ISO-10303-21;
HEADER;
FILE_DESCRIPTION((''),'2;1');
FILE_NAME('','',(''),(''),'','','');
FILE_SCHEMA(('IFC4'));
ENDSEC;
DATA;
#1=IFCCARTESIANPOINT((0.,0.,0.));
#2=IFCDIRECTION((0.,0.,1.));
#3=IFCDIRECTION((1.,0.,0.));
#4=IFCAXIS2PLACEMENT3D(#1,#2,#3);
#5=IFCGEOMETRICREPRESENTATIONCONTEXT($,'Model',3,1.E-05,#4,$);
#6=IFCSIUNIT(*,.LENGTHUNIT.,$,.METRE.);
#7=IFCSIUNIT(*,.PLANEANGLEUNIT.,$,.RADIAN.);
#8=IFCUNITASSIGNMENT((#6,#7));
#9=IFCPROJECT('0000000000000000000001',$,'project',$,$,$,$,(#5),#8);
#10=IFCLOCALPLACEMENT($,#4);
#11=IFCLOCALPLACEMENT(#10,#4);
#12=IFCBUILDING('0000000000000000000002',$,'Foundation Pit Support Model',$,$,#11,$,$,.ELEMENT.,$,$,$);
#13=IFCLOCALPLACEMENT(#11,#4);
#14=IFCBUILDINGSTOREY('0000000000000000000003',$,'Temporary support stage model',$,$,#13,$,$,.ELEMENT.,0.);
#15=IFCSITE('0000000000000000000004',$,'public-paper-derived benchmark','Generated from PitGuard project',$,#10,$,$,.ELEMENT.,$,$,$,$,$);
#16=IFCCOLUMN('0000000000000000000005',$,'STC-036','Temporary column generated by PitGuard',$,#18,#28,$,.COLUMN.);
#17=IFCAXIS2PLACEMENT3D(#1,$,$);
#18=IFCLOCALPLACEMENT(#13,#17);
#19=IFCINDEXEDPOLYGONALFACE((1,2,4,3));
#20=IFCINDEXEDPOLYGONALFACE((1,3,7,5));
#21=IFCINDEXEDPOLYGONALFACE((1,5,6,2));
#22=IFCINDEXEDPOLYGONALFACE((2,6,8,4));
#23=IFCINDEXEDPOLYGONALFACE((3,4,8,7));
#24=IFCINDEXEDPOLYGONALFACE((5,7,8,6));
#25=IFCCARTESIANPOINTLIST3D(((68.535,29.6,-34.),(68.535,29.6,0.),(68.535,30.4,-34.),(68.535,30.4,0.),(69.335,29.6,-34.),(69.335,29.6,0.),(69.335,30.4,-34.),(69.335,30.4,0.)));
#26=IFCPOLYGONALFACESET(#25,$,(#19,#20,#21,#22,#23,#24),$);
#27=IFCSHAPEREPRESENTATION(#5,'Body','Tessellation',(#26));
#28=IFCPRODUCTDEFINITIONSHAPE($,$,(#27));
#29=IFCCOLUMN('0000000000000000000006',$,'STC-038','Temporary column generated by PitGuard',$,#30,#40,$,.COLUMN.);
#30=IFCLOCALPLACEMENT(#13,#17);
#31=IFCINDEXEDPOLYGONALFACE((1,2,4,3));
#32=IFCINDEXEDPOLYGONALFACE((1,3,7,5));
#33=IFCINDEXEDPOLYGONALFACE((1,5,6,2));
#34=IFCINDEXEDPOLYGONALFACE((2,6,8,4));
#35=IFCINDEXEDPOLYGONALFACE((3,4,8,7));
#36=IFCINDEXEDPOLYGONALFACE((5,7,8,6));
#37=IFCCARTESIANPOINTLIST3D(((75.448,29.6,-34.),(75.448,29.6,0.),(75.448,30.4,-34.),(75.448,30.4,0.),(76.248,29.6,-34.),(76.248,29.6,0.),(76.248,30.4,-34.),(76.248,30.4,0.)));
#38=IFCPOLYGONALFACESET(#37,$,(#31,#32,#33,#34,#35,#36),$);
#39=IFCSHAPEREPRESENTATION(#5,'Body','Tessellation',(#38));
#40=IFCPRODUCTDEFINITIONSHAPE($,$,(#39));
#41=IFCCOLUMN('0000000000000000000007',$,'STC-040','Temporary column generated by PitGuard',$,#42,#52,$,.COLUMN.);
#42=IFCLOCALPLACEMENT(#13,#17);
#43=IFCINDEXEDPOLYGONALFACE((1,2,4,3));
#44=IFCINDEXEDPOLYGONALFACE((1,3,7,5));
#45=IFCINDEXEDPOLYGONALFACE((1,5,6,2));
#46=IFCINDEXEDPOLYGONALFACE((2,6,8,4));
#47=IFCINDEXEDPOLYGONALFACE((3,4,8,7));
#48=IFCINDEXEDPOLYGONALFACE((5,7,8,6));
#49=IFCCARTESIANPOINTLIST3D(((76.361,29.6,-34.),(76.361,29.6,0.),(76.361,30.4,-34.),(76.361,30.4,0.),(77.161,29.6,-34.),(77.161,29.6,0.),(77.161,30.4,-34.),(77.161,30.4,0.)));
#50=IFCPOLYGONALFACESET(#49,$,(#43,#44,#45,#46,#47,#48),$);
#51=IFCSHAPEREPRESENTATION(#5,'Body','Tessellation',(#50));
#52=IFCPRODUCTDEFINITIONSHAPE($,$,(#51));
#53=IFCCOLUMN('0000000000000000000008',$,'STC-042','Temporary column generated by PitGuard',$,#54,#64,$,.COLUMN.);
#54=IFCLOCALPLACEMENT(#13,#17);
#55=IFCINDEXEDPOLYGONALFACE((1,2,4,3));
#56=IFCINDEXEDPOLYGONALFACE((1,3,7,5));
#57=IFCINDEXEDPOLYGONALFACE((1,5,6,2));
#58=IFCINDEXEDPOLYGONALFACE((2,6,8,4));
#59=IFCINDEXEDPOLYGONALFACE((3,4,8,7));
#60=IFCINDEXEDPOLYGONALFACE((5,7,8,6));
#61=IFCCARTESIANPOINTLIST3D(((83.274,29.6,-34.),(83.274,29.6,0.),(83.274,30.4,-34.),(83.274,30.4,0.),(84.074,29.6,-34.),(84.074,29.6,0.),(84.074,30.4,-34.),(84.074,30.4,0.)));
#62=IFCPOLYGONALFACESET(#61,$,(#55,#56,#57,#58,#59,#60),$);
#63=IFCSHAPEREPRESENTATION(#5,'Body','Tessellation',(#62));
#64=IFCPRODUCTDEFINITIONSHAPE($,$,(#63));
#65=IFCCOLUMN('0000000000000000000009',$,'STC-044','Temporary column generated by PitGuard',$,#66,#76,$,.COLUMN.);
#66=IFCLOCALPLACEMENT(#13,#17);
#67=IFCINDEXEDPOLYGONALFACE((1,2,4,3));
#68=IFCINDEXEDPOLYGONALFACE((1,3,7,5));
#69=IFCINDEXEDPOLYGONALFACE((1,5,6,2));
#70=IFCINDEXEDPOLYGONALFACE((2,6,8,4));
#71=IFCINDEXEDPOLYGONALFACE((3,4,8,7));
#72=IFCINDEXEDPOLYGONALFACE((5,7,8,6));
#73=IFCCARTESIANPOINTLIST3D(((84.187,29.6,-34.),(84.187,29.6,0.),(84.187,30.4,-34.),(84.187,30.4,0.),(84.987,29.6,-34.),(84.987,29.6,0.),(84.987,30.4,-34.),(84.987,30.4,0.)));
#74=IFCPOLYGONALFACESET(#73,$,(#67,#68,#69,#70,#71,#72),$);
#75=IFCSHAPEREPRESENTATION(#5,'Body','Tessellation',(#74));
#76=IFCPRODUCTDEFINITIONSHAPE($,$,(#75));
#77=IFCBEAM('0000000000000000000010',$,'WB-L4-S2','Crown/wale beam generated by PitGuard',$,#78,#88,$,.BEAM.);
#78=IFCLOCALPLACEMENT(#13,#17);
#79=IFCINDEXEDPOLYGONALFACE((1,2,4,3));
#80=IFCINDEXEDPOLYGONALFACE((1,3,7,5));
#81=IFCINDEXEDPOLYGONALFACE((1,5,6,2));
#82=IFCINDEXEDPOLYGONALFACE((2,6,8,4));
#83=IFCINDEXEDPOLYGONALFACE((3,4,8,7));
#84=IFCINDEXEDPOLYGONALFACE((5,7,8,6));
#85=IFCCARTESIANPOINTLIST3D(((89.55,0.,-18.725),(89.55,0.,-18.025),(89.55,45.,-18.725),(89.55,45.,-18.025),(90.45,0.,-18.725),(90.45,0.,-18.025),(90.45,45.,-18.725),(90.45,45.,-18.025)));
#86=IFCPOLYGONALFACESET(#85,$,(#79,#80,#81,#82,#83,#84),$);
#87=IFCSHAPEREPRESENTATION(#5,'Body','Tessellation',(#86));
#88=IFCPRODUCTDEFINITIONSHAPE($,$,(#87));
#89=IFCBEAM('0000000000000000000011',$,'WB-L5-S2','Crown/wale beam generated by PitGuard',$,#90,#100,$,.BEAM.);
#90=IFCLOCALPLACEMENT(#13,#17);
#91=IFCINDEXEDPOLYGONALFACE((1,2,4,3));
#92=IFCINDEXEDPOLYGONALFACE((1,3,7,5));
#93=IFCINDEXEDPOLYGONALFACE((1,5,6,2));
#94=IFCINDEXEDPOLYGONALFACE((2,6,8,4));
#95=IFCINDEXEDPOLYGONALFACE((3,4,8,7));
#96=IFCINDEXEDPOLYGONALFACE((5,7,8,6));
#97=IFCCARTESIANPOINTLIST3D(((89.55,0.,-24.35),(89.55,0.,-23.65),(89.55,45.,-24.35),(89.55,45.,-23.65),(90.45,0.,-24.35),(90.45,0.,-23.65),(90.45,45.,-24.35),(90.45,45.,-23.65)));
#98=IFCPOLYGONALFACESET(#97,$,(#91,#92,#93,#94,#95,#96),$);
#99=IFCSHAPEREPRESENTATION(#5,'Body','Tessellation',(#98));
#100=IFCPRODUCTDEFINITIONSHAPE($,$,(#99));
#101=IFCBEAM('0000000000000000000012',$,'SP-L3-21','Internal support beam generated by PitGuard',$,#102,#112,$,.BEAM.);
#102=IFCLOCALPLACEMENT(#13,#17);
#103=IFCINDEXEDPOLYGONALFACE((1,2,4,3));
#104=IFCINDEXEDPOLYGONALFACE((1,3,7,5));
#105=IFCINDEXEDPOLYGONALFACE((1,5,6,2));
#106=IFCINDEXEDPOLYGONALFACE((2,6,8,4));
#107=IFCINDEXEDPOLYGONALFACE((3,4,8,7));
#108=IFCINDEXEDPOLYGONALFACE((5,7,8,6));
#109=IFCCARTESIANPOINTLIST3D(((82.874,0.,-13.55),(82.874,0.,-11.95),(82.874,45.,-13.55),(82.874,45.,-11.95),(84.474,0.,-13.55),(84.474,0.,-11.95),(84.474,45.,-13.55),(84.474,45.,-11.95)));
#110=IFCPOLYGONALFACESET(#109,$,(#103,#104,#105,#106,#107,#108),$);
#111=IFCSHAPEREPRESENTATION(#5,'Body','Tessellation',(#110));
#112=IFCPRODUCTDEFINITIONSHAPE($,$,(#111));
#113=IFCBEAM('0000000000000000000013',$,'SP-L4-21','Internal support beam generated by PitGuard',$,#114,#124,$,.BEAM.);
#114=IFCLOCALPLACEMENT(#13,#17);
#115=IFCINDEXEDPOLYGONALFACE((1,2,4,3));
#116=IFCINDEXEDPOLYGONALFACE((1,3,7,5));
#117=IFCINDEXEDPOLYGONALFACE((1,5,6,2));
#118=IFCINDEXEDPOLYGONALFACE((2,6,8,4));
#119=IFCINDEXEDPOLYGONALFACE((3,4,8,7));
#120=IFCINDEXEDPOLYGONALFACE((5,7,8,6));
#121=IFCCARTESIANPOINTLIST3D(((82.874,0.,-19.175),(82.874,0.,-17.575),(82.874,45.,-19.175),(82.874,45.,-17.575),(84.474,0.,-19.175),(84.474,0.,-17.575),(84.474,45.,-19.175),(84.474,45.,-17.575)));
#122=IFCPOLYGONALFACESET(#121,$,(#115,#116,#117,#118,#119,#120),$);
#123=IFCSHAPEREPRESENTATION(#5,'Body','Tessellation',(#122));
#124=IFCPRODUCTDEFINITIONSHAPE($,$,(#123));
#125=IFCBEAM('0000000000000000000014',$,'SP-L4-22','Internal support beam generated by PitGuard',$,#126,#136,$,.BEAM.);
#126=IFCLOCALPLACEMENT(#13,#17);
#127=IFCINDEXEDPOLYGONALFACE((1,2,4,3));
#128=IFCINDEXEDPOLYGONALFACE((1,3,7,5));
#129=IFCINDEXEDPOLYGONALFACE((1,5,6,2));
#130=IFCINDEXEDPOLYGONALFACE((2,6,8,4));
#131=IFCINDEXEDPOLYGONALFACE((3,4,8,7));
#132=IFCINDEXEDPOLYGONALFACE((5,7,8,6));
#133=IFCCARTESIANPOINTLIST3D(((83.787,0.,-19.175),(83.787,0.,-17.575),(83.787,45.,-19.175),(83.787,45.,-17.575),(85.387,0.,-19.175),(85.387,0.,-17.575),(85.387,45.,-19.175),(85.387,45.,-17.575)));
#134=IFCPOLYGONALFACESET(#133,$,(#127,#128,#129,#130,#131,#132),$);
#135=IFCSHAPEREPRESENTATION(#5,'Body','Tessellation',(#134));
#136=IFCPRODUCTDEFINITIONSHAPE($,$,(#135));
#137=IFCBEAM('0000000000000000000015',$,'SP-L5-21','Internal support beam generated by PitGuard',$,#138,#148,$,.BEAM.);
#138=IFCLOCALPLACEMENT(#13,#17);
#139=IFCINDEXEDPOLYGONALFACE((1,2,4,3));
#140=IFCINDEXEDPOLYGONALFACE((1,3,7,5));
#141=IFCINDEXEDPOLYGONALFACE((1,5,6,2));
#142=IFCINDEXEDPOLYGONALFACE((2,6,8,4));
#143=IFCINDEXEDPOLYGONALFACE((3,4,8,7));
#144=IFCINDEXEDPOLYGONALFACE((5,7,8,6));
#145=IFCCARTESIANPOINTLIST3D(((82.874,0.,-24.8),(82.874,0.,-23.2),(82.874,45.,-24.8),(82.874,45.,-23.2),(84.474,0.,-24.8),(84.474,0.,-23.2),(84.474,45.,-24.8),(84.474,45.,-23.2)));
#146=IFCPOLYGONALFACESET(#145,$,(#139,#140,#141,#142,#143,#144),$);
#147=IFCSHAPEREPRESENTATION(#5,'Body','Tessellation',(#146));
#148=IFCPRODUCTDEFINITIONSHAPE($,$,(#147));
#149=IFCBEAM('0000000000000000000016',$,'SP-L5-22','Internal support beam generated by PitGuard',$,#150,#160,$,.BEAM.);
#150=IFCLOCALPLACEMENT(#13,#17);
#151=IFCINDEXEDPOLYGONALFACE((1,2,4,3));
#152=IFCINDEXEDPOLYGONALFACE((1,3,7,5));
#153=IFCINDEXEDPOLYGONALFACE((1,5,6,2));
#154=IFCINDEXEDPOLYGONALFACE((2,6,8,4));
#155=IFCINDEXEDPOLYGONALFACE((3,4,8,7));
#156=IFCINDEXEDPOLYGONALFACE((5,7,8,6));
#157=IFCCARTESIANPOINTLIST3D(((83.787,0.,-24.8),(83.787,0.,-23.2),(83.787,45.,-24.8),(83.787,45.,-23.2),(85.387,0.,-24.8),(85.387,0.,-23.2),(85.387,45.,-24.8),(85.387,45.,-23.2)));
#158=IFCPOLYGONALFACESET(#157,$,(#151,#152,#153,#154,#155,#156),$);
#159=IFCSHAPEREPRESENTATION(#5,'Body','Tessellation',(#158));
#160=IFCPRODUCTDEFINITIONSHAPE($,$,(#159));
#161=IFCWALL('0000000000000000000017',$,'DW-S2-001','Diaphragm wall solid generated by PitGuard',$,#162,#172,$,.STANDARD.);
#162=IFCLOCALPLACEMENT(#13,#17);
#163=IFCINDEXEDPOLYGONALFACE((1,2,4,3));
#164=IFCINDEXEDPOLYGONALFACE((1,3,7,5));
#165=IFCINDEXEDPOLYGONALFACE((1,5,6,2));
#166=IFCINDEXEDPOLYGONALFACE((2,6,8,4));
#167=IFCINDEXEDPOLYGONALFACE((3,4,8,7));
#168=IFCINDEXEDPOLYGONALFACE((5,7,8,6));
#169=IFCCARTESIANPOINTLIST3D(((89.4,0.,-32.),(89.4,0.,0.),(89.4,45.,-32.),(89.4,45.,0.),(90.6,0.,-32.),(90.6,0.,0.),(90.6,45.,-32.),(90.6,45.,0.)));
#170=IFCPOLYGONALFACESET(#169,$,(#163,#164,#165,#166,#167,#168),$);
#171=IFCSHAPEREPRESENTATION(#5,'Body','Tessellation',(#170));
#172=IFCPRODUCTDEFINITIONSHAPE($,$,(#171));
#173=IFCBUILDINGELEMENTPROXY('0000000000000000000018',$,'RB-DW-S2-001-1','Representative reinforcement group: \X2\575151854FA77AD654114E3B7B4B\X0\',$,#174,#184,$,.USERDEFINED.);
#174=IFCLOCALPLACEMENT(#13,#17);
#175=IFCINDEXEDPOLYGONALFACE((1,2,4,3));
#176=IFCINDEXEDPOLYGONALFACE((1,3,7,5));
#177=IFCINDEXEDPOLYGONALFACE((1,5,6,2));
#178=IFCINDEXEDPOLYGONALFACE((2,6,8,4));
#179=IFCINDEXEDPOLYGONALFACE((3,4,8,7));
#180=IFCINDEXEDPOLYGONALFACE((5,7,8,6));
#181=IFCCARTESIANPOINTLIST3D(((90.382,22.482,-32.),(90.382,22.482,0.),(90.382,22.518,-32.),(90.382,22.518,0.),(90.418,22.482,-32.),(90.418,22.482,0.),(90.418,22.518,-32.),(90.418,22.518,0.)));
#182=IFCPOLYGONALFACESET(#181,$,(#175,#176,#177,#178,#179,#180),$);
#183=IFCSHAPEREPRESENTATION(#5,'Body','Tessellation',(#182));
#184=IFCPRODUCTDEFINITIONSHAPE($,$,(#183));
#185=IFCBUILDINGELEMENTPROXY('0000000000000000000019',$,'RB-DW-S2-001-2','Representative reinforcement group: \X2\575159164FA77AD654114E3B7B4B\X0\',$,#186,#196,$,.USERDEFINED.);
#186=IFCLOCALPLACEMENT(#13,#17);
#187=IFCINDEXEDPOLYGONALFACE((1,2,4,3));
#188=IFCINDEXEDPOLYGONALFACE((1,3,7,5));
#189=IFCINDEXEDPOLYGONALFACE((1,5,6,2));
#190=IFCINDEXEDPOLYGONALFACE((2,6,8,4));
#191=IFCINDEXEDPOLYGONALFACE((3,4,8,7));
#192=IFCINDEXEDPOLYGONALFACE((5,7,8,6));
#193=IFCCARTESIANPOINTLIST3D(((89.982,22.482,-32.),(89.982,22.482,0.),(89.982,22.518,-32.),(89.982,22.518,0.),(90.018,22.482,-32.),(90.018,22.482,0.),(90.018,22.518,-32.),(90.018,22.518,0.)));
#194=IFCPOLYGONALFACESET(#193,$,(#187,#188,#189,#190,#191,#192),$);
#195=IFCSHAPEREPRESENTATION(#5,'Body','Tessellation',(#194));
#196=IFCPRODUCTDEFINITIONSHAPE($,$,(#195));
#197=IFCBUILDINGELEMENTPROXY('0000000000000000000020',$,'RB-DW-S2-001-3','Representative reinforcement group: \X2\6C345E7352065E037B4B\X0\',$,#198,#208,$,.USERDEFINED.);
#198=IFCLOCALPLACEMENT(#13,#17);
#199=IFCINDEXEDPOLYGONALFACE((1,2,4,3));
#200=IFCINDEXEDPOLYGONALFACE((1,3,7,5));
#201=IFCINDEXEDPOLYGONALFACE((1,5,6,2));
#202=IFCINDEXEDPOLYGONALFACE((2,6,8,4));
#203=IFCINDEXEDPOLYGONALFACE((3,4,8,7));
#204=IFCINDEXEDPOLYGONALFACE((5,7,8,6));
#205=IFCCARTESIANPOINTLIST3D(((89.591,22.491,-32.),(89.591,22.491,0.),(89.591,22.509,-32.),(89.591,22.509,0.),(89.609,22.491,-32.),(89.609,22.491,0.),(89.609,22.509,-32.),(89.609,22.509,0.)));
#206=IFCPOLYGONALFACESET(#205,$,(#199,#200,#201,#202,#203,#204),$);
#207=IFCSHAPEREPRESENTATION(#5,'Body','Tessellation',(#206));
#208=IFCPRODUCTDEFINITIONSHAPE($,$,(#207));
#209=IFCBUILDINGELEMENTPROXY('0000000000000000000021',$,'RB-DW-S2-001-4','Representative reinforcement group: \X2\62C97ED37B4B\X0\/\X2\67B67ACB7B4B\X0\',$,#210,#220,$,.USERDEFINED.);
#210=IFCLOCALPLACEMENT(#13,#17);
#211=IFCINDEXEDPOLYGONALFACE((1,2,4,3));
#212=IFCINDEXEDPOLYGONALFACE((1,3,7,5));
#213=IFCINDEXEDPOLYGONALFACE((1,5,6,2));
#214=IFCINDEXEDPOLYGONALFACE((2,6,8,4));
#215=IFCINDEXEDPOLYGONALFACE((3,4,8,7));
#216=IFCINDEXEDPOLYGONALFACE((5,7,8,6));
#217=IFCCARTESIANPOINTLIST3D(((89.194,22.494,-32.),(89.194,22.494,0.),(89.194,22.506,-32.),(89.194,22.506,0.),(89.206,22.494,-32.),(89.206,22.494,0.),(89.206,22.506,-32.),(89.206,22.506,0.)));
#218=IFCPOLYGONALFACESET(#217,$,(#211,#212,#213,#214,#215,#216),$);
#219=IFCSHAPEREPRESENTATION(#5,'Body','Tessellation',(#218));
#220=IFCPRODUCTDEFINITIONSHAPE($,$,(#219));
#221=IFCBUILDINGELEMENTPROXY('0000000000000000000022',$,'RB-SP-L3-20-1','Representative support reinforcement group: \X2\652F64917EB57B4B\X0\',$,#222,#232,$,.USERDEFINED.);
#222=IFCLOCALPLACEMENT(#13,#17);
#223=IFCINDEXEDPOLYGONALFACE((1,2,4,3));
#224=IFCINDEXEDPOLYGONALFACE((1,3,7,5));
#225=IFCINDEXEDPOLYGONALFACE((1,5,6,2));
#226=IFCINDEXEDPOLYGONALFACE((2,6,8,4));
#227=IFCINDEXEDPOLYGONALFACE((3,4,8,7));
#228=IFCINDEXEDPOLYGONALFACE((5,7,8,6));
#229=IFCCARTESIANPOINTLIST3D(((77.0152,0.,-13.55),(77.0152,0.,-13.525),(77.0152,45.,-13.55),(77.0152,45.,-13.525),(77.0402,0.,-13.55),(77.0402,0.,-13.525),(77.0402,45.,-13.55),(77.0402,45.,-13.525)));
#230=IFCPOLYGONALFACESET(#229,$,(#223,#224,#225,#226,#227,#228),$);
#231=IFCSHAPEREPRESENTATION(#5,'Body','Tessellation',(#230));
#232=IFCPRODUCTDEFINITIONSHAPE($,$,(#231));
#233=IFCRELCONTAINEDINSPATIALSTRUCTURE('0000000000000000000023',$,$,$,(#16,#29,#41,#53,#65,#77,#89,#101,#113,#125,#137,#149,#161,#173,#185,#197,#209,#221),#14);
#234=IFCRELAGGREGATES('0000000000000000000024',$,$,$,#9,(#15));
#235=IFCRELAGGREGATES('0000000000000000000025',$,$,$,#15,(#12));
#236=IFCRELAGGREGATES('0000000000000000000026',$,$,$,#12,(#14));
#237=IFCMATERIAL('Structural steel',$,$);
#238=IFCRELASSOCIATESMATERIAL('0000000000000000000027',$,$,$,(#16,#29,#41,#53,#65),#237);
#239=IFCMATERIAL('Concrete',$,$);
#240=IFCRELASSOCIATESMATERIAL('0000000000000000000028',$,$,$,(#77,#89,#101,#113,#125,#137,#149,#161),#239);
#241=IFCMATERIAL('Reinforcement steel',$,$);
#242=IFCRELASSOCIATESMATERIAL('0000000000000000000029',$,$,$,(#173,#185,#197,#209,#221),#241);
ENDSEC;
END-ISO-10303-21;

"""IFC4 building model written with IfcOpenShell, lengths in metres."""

from ifc_helpers import new_model, si_unit, frame, origin_with_axes, origin_2d, place, context, project, spatial, rectangle, extrude, material, element, save


model = new_model("IFC4")

# Units and contexts
model_context = context("Model", 3, precision=1e-05, world=origin_with_axes())
ifc_project = project(units=[si_unit("LENGTHUNIT", "METRE"), si_unit("PLANEANGLEUNIT", "RADIAN")], contexts=[model_context])

# Site, building, storey
site_placement = place(None, origin_with_axes())
site = spatial("IfcSite", under=ifc_project, at=site_placement, Name="public-paper-derived benchmark", Description="Generated from PitGuard project", CompositionType="ELEMENT")
building_placement = place(site_placement, origin_with_axes())
building = spatial("IfcBuilding", under=site, at=building_placement, Name="Foundation Pit Support Model", CompositionType="ELEMENT")
storey_placement = place(building_placement, origin_with_axes())
storey = spatial("IfcBuildingStorey", under=building, at=storey_placement, Name="Temporary support stage model", CompositionType="ELEMENT", Elevation=0.0)

# Columns
ifc_material_1 = material(Name="Structural steel")
for number, where, z_axis, x_axis, name in (
    (1, (68.935, 30.0, -34.0), (0.0, 0.0, 1.0), (1.0, 0.0, 0.0), "STC-036"),
    (2, (75.848, 30.0, -34.0), (0.0, 0.0, 1.0), (1.0, 0.0, 0.0), "STC-038"),
    (3, (76.761, 30.0, -34.0), (0.0, 0.0, 1.0), (1.0, 0.0, 0.0), "STC-040"),
    (4, (83.674, 30.0, -34.0), (0.0, 0.0, 1.0), (1.0, 0.0, 0.0), "STC-042"),
    (5, (84.587, 30.0, -34.0), (0.0, 0.0, 1.0), (1.0, 0.0, 0.0), "STC-044"),
):
    element("IfcColumn", number, at=place(storey_placement, frame(where, z_axis=z_axis, x_axis=x_axis)), inside=storey, material=ifc_material_1, Name=name, Description="Temporary column generated by PitGuard", PredefinedType="COLUMN", context=model_context, shape_type="SweptSolid", body=[
        extrude(rectangle(XDim=0.8, YDim=0.8, at=origin_2d()), origin_with_axes(), (0.0, 0.0, 1.0), 34.0),
    ])

# Beams
ifc_material_2 = material(Name="Concrete")
for number, where, z_axis, x_axis, name in (
    (6, (90.0, 22.5, -18.725), (0.0, 0.0, 1.0), (0.0, 1.0, 0.0), "WB-L4-S2"),
    (7, (90.0, 22.5, -24.35), (0.0, 0.0, 1.0), (0.0, 1.0, 0.0), "WB-L5-S2"),
):
    element("IfcBeam", number, at=place(storey_placement, frame(where, z_axis=z_axis, x_axis=x_axis)), inside=storey, material=ifc_material_2, Name=name, Description="Crown/wale beam generated by PitGuard", PredefinedType="BEAM", context=model_context, shape_type="SweptSolid", body=[
        extrude(rectangle(XDim=45.0, YDim=0.9, at=origin_2d()), origin_with_axes(), (0.0, 0.0, 1.0), 0.7),
    ])
for number, where, z_axis, x_axis, name in (
    (8, (83.674, 22.5, -13.55), (0.0, 0.0, 1.0), (0.0, 1.0, 0.0), "SP-L3-21"),
    (9, (83.674, 22.5, -19.175), (0.0, 0.0, 1.0), (0.0, 1.0, 0.0), "SP-L4-21"),
    (10, (84.587, 22.5, -19.175), (0.0, 0.0, 1.0), (0.0, 1.0, 0.0), "SP-L4-22"),
    (11, (83.674, 22.5, -24.8), (0.0, 0.0, 1.0), (0.0, 1.0, 0.0), "SP-L5-21"),
    (12, (84.587, 22.5, -24.8), (0.0, 0.0, 1.0), (0.0, 1.0, 0.0), "SP-L5-22"),
):
    element("IfcBeam", number, at=place(storey_placement, frame(where, z_axis=z_axis, x_axis=x_axis)), inside=storey, material=ifc_material_2, Name=name, Description="Internal support beam generated by PitGuard", PredefinedType="BEAM", context=model_context, shape_type="SweptSolid", body=[
        extrude(rectangle(XDim=45.0, YDim=1.6, at=origin_2d()), origin_with_axes(), (0.0, 0.0, 1.0), 1.6),
    ])

# Wall
wall_placement = place(storey_placement, frame((90.0, 22.5, -32.0), z_axis=(0.0, 0.0, 1.0), x_axis=(0.0, 1.0, 0.0)))
element("IfcWall", 13, at=wall_placement, inside=storey, material=ifc_material_2, Name="DW-S2-001", Description="Diaphragm wall solid generated by PitGuard", PredefinedType="STANDARD", context=model_context, shape_type="SweptSolid", body=[
    extrude(rectangle(XDim=45.0, YDim=1.2, at=origin_2d()), origin_with_axes(), (0.0, 0.0, 1.0), 32.0),
])

# Building element proxies
ifc_material_3 = material(Name="Reinforcement steel")
for number, where, z_axis, x_axis, name, description in (
    (14, (90.4, 22.5, -32.0), (0.0, 0.0, 1.0), (1.0, 0.0, 0.0), "RB-DW-S2-001-1", "Representative reinforcement group: 坑内侧竖向主筋"),
    (15, (90.0, 22.5, -32.0), (0.0, 0.0, 1.0), (1.0, 0.0, 0.0), "RB-DW-S2-001-2", "Representative reinforcement group: 坑外侧竖向主筋"),
):
    element("IfcBuildingElementProxy", number, at=place(storey_placement, frame(where, z_axis=z_axis, x_axis=x_axis)), inside=storey, material=ifc_material_3, Name=name, Description=description, PredefinedType="USERDEFINED", context=model_context, shape_type="SweptSolid", body=[
        extrude(rectangle(XDim=0.036, YDim=0.036, at=origin_2d()), origin_with_axes(), (0.0, 0.0, 1.0), 32.0),
    ])
proxy_1_placement = place(storey_placement, frame((89.6, 22.5, -32.0), z_axis=(0.0, 0.0, 1.0), x_axis=(1.0, 0.0, 0.0)))
element("IfcBuildingElementProxy", 16, at=proxy_1_placement, inside=storey, material=ifc_material_3, Name="RB-DW-S2-001-3", Description="Representative reinforcement group: 水平分布筋", PredefinedType="USERDEFINED", context=model_context, shape_type="SweptSolid", body=[
    extrude(rectangle(XDim=0.018, YDim=0.018, at=origin_2d()), origin_with_axes(), (0.0, 0.0, 1.0), 32.0),
])
proxy_2_placement = place(storey_placement, frame((89.2, 22.5, -32.0), z_axis=(0.0, 0.0, 1.0), x_axis=(1.0, 0.0, 0.0)))
element("IfcBuildingElementProxy", 17, at=proxy_2_placement, inside=storey, material=ifc_material_3, Name="RB-DW-S2-001-4", Description="Representative reinforcement group: 拉结筋/架立筋", PredefinedType="USERDEFINED", context=model_context, shape_type="SweptSolid", body=[
    extrude(rectangle(XDim=0.012, YDim=0.012, at=origin_2d()), origin_with_axes(), (0.0, 0.0, 1.0), 32.0),
])
for number, where, z_axis, x_axis, name in (
    (18, (77.0277, 22.5, -13.55), (0.0, 0.0, 1.0), (0.0, 1.0, 0.0), "RB-SP-L3-20-1"),
):
    element("IfcBuildingElementProxy", number, at=place(storey_placement, frame(where, z_axis=z_axis, x_axis=x_axis)), inside=storey, material=ifc_material_3, Name=name, Description="Representative support reinforcement group: 支撑纵筋", PredefinedType="USERDEFINED", context=model_context, shape_type="SweptSolid", body=[
        extrude(rectangle(XDim=45.0, YDim=0.025, at=origin_2d()), origin_with_axes(), (0.0, 0.0, 1.0), 0.025),
    ])

save(model, "model.ifc")
